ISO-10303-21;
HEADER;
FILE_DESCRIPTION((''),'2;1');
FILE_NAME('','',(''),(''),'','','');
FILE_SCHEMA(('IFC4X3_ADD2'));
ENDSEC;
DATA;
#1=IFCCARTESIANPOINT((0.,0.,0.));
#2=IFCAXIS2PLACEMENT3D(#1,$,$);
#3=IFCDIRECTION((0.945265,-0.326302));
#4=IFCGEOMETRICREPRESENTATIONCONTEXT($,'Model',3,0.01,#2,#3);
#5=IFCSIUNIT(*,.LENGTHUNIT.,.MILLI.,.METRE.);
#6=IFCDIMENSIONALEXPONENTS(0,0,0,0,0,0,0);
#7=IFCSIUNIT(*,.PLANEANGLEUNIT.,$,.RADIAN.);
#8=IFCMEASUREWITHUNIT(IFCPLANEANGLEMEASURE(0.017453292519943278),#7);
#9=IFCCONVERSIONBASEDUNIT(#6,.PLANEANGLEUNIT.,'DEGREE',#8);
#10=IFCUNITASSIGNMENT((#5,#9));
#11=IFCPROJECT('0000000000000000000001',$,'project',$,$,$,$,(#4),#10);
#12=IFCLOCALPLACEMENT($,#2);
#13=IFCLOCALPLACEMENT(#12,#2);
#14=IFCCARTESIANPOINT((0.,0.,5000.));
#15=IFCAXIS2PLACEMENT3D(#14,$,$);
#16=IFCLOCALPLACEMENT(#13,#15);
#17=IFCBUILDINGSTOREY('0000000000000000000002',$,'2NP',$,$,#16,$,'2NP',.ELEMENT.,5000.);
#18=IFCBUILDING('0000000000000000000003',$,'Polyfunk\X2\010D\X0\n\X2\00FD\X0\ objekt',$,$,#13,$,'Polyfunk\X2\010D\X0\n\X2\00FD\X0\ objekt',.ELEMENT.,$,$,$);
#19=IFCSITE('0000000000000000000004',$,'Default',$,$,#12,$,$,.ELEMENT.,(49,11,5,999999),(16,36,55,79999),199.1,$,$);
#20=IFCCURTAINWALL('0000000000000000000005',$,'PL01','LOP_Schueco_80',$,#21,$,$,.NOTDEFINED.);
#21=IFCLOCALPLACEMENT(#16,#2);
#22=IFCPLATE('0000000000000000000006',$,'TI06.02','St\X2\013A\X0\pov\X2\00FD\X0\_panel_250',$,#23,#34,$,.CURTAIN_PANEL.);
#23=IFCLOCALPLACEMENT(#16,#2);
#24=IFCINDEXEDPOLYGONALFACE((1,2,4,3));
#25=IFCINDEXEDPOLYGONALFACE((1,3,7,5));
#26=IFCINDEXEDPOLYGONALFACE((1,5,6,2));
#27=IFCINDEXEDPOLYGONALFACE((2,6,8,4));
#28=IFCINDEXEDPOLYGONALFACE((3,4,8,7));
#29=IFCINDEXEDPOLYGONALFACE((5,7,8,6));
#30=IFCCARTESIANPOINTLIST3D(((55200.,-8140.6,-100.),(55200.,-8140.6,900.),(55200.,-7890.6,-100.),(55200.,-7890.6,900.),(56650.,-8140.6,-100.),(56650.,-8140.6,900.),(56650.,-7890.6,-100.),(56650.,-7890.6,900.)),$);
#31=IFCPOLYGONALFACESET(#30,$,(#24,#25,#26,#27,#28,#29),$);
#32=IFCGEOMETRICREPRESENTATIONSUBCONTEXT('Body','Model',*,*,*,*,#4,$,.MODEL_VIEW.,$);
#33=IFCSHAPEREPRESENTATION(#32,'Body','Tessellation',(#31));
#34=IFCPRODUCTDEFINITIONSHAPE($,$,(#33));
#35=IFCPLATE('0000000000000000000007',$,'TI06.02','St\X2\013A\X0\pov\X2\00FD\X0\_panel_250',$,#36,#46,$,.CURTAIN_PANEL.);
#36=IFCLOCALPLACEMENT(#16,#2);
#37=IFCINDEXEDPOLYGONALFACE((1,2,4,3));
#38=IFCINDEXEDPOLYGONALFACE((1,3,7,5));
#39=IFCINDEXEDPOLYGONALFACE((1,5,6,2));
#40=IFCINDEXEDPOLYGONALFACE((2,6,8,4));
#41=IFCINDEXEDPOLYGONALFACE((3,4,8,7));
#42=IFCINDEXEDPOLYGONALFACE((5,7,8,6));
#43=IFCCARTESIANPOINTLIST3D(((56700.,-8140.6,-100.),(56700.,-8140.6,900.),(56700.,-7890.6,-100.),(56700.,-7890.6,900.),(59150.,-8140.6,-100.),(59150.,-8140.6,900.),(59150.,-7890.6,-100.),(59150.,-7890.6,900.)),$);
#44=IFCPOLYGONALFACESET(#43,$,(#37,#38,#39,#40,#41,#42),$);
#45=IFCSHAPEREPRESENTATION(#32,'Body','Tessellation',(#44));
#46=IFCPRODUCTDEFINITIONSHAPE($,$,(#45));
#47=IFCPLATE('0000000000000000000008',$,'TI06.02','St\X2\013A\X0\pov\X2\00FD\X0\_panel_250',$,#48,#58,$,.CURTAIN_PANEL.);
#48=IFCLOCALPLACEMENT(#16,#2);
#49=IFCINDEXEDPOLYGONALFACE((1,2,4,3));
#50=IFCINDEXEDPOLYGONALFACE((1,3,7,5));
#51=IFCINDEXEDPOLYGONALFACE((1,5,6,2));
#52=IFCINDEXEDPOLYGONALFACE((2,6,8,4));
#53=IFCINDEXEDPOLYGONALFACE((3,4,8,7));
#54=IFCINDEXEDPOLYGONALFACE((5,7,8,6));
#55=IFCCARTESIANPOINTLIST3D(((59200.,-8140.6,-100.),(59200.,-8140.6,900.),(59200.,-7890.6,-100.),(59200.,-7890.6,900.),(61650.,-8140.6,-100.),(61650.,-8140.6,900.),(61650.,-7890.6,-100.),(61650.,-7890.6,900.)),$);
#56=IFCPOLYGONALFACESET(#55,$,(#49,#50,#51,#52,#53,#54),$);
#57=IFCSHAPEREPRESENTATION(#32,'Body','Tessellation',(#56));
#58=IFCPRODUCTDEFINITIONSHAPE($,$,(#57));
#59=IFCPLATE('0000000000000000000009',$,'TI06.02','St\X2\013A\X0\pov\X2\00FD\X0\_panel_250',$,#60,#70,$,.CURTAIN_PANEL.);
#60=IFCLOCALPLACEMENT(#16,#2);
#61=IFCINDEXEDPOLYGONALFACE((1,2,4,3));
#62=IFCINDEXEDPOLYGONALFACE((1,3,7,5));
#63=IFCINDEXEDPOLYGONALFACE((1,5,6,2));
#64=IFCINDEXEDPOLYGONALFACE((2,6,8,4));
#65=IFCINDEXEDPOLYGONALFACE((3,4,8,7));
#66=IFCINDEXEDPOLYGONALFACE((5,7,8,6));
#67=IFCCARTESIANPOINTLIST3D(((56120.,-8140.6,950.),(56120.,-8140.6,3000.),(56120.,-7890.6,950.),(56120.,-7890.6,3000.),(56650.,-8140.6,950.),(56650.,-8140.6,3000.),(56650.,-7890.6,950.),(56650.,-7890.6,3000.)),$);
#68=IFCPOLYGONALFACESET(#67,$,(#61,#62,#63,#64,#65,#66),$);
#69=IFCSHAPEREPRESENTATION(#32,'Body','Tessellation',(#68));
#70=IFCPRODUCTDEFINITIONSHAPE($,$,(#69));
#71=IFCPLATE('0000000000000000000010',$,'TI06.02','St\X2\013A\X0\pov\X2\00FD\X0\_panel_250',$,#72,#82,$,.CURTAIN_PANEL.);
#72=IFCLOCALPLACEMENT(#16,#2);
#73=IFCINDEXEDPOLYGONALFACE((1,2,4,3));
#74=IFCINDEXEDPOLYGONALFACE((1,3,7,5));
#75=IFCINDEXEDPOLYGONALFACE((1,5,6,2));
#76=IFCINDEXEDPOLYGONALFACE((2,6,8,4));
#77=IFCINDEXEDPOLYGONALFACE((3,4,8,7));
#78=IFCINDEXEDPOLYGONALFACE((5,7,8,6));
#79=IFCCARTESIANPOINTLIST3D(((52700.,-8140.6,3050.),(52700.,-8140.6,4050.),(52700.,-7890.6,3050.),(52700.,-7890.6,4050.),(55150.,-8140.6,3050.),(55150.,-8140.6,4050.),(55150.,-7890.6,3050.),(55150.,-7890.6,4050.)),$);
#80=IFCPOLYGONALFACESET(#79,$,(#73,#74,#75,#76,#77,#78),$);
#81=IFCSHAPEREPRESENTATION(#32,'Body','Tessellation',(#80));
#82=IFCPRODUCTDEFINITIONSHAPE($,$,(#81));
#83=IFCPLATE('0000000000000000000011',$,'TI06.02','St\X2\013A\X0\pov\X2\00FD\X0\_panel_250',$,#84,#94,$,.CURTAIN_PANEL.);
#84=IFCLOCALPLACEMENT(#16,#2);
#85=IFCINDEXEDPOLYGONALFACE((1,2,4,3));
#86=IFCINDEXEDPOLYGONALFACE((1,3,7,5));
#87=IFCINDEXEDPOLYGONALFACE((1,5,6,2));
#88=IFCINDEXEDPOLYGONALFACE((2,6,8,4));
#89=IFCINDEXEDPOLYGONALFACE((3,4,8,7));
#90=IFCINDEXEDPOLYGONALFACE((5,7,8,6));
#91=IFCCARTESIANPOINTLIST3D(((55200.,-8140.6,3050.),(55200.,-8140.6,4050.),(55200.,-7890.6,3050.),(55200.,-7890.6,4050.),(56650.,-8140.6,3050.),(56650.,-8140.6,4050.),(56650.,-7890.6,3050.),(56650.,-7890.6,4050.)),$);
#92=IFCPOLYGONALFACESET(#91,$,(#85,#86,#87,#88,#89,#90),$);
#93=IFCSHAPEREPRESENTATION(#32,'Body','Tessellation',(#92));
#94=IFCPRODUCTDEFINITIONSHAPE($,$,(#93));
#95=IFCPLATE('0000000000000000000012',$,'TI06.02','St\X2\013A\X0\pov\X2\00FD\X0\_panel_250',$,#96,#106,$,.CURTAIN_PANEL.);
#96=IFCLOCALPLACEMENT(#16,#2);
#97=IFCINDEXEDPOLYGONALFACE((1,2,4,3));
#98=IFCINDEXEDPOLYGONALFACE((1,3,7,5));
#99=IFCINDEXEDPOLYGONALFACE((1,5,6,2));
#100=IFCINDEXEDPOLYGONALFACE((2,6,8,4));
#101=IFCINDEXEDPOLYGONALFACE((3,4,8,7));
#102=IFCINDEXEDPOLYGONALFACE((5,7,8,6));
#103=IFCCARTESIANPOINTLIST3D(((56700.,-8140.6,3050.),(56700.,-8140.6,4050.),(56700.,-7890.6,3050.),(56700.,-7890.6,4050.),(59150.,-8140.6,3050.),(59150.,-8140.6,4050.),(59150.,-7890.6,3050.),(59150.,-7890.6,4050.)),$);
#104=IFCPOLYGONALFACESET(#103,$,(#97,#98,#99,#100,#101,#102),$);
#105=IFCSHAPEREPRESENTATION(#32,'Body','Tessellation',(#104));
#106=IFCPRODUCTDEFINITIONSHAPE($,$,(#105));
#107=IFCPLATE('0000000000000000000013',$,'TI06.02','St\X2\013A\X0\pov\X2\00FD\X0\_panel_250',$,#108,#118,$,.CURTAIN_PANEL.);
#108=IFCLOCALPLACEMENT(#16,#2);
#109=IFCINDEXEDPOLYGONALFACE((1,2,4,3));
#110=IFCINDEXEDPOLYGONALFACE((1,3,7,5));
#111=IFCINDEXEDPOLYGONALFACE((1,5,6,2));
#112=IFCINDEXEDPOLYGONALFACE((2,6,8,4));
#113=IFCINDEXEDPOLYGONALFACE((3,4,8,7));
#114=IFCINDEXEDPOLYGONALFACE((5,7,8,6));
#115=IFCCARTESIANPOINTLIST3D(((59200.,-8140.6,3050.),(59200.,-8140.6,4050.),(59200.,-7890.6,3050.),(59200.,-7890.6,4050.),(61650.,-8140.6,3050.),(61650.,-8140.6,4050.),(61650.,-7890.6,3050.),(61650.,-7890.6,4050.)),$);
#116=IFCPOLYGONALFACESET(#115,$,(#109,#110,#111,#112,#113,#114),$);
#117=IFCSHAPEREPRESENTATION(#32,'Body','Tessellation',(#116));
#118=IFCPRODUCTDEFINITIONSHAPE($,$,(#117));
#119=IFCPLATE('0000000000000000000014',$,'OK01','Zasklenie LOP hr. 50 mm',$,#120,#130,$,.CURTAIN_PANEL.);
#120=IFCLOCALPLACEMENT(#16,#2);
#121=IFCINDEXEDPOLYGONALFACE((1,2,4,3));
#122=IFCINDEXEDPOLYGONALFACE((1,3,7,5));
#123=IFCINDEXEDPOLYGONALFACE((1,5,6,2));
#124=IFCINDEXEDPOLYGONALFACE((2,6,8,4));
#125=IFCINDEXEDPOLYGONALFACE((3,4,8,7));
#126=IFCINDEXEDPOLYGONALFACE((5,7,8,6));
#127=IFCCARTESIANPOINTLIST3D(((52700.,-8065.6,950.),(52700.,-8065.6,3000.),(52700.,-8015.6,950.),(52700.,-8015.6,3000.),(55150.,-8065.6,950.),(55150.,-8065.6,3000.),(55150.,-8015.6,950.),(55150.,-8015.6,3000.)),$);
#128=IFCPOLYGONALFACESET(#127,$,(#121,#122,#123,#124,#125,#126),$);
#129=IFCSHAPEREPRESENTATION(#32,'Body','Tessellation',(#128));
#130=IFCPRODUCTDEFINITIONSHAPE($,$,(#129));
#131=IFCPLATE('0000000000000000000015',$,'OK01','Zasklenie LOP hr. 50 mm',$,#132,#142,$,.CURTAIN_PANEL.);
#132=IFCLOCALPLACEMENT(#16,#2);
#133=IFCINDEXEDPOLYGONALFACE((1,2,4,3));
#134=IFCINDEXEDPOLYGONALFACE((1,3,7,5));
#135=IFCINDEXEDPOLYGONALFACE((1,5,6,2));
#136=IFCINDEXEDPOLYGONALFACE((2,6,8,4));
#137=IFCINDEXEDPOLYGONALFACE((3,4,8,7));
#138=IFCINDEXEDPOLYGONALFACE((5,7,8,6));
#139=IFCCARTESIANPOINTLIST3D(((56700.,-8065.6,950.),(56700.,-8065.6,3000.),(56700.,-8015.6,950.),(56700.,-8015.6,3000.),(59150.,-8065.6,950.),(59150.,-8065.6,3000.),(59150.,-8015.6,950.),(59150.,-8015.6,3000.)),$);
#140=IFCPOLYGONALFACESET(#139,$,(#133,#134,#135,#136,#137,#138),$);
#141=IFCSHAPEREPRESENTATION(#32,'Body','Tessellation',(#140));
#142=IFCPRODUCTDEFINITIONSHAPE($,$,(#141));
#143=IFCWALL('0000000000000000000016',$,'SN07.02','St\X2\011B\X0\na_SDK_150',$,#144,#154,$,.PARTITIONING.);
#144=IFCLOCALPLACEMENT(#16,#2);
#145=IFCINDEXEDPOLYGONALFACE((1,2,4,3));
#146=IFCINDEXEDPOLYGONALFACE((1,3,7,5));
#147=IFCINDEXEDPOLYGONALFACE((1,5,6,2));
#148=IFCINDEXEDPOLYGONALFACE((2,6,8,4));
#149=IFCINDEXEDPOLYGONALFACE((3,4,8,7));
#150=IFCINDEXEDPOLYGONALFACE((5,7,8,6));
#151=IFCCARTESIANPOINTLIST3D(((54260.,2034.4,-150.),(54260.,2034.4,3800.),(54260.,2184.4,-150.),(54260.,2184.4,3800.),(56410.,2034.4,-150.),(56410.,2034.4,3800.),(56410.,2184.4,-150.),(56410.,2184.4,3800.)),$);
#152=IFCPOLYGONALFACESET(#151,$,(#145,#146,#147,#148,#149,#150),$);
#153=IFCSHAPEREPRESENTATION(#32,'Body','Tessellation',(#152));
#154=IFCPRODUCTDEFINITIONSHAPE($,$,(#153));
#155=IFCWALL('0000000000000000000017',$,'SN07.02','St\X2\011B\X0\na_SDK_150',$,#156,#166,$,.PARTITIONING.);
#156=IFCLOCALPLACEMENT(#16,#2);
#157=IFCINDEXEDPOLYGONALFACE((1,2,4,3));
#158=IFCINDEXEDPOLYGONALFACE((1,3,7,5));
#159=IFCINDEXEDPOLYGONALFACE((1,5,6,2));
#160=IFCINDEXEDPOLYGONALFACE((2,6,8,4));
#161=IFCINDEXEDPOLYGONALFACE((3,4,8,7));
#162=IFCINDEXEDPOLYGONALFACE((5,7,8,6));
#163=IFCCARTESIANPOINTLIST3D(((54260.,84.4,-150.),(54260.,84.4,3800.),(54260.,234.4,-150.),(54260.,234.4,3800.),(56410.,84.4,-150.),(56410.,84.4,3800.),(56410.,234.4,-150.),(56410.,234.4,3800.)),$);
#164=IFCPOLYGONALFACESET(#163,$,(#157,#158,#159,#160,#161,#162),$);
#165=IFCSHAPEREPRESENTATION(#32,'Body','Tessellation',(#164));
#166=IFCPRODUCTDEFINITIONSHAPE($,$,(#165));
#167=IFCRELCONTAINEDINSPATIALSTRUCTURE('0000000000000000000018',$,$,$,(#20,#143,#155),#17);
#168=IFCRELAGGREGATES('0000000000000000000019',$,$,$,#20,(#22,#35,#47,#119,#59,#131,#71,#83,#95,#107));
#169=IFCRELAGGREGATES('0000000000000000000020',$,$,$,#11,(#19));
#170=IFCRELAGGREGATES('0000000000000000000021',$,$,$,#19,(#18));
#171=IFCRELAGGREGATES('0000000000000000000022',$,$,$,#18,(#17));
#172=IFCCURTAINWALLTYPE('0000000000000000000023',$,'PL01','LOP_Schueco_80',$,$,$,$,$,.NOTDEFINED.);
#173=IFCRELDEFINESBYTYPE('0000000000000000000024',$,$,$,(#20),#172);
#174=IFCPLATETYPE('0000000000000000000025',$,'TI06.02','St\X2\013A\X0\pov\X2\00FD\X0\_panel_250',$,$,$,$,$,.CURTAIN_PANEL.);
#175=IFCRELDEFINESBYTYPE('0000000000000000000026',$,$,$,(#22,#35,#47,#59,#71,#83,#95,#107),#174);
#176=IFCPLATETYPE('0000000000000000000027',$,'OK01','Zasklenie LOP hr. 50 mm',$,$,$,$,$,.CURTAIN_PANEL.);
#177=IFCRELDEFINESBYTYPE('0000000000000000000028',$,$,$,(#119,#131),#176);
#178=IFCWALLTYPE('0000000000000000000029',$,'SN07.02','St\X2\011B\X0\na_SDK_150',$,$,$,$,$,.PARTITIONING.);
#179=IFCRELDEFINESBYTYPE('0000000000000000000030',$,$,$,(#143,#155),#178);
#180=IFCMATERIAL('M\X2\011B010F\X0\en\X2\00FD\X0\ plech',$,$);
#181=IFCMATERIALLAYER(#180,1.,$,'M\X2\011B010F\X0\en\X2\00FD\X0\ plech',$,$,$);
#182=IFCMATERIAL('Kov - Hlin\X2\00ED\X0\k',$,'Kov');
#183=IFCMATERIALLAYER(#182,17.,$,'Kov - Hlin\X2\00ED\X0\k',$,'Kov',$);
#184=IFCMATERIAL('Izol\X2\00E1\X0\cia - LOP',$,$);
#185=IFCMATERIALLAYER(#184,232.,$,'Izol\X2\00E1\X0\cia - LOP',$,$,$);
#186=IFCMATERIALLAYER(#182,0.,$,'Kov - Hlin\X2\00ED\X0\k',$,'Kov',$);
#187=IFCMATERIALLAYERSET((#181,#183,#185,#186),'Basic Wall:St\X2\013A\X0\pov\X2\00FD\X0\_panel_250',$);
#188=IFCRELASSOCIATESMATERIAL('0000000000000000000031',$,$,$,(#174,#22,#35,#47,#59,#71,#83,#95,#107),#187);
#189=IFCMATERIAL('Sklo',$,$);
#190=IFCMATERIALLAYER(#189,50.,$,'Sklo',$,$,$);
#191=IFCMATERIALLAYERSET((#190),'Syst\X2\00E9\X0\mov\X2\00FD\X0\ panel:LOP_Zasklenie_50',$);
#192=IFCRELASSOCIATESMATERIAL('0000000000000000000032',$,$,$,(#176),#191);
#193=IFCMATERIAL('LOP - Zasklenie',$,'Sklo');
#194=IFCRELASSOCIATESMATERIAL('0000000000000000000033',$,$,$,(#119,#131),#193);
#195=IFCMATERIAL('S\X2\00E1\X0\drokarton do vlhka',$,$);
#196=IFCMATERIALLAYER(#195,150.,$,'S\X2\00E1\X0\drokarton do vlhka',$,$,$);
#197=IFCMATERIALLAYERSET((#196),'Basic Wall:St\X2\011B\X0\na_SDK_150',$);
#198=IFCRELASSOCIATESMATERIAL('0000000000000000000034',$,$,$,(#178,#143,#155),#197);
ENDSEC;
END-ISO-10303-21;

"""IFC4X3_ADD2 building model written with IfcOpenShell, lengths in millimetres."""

from ifc_helpers import new_model, entity, si_unit, converted_unit, direction, frame, frame_2d, origin, origin_2d_with_axis, place, context, subcontext, project, spatial, polyline, rectangle, extrude, clip, bounded_halfspace, source, transform, mapped, material, layer, layer_set, layer_usage, type_object, type_shapes, element, aggregate, save


model = new_model("IFC4X3_ADD2")

# Units and contexts
model_context = context("Model", 3, precision=0.01, world=origin(), true_north=direction((0.945265, -0.326302)))
body_context = subcontext(model_context, "Body", "Model", "MODEL_VIEW")
ifc_project = project(units=[si_unit("LENGTHUNIT", "METRE", prefix="MILLI"), converted_unit("PLANEANGLEUNIT", "DEGREE", entity("IfcPlaneAngleMeasure", 0.017453292519943278), si_unit("PLANEANGLEUNIT", "RADIAN"), dimensions=[0, 0, 0, 0, 0, 0, 0])], contexts=[model_context])

# Site, building, storey
site_placement = place(None, origin())
site = spatial("IfcSite", under=ifc_project, at=site_placement, Name="Default", CompositionType="ELEMENT", RefLatitude=(49, 11, 5, 999999), RefLongitude=(16, 36, 55, 79999), RefElevation=199.1)
building_placement = place(site_placement, origin())
building = spatial("IfcBuilding", under=site, at=building_placement, Name="Polyfunkčný objekt", LongName="Polyfunkčný objekt", CompositionType="ELEMENT")
storey_placement = place(building_placement, frame((0.0, 0.0, 5000.0)))
storey = spatial("IfcBuildingStorey", under=building, at=storey_placement, Name="2NP", LongName="2NP", CompositionType="ELEMENT", Elevation=5000.0)

# Curtain wall, plates
curtain_wall_type = type_object("IfcCurtainWallType", Name="PL01", Description="LOP_Schueco_80", PredefinedType="NOTDEFINED")
curtain_wall_placement = place(storey_placement, frame((0.0, 0.0, -5000.0)))
curtain_wall = element("IfcCurtainWall", 1, at=curtain_wall_placement, inside=storey, type_object=curtain_wall_type, Name="PL01", Description="LOP_Schueco_80", PredefinedType="NOTDEFINED")
ifc_material_1 = material(Name="Měďený plech")
ifc_layer_1 = layer(ifc_material_1, 1.0, Name="Měďený plech")
ifc_material_2 = material(Name="Kov - Hliník", Category="Kov")
ifc_layer_2 = layer(ifc_material_2, 17.0, Name="Kov - Hliník", Category="Kov")
ifc_material_3 = material(Name="Izolácia - LOP")
ifc_layer_3 = layer(ifc_material_3, 232.0, Name="Izolácia - LOP")
ifc_layer_4 = layer(ifc_material_2, 0.0, Name="Kov - Hliník", Category="Kov")
ifc_layer_set_1 = layer_set([ifc_layer_1, ifc_layer_2, ifc_layer_3, ifc_layer_4], Name="Basic Wall:Stĺpový_panel_250")
ifc_layer_usage_1 = layer_usage(ifc_layer_set_1, "AXIS2", "POSITIVE", -125.0)
plate_type_1 = type_object("IfcPlateType", Name="TI06.02", Description="Stĺpový_panel_250", PredefinedType="CURTAIN_PANEL", material=ifc_layer_set_1)
plate_1_placement = place(storey_placement, frame((55200.0, -8015.6, -100.0)))
plate_1 = element("IfcPlate", 2, at=plate_1_placement, type_object=plate_type_1, material=ifc_layer_usage_1, Name="TI06.02", Description="Stĺpový_panel_250", PredefinedType="CURTAIN_PANEL", context=body_context, shape_type="SweptSolid", body=[
    extrude(rectangle(XDim=250.0, YDim=1450.0, at=frame_2d((0.0, 0.0), x_axis=(1.0, 0.0))), frame((725.0, 0.0, 0.0), z_axis=(0.0, 0.0, 1.0), x_axis=(0.0, 1.0, 0.0)), (0.0, 0.0, 1.0), 1000.0),
])
ifc_layer_usage_2 = layer_usage(ifc_layer_set_1, "AXIS2", "POSITIVE", -125.0)
plate_2_placement = place(storey_placement, frame((56700.0, -8015.6, -100.0)))
plate_2 = element("IfcPlate", 3, at=plate_2_placement, type_object=plate_type_1, material=ifc_layer_usage_2, Name="TI06.02", Description="Stĺpový_panel_250", PredefinedType="CURTAIN_PANEL", context=body_context, shape_type="SweptSolid", body=[
    extrude(rectangle(XDim=250.0, YDim=2450.0, at=frame_2d((0.0, 0.0), x_axis=(1.0, 0.0))), frame((1225.0, 0.0, 0.0), z_axis=(0.0, 0.0, 1.0), x_axis=(0.0, 1.0, 0.0)), (0.0, 0.0, 1.0), 1000.0),
])
ifc_layer_usage_3 = layer_usage(ifc_layer_set_1, "AXIS2", "POSITIVE", -125.0)
plate_3_placement = place(storey_placement, frame((59200.0, -8015.6, -100.0)))
plate_3 = element("IfcPlate", 4, at=plate_3_placement, type_object=plate_type_1, material=ifc_layer_usage_3, Name="TI06.02", Description="Stĺpový_panel_250", PredefinedType="CURTAIN_PANEL", context=body_context, shape_type="SweptSolid", body=[
    extrude(rectangle(XDim=250.0, YDim=2450.0, at=frame_2d((0.0, 0.0), x_axis=(1.0, 0.0))), frame((1225.0, 0.0, 0.0), z_axis=(0.0, 0.0, 1.0), x_axis=(0.0, 1.0, 0.0)), (0.0, 0.0, 1.0), 1000.0),
])
ifc_layer_usage_4 = layer_usage(ifc_layer_set_1, "AXIS2", "POSITIVE", -125.0)
plate_4_placement = place(storey_placement, frame((56120.0, -8015.6, 950.0)))
plate_4 = element("IfcPlate", 5, at=plate_4_placement, type_object=plate_type_1, material=ifc_layer_usage_4, Name="TI06.02", Description="Stĺpový_panel_250", PredefinedType="CURTAIN_PANEL", context=body_context, shape_type="SweptSolid", body=[
    extrude(rectangle(XDim=250.0, YDim=530.0, at=origin_2d_with_axis()), frame((265.0, 0.0, 0.0), z_axis=(0.0, 0.0, 1.0), x_axis=(0.0, 1.0, 0.0)), (0.0, 0.0, 1.0), 2050.0),
])
ifc_layer_usage_5 = layer_usage(ifc_layer_set_1, "AXIS2", "POSITIVE", -125.0)
plate_5_placement = place(storey_placement, frame((52700.0, -8015.6, 3050.0)))
plate_5 = element("IfcPlate", 6, at=plate_5_placement, type_object=plate_type_1, material=ifc_layer_usage_5, Name="TI06.02", Description="Stĺpový_panel_250", PredefinedType="CURTAIN_PANEL", context=body_context, shape_type="SweptSolid", body=[
    extrude(rectangle(XDim=250.0, YDim=2450.0, at=frame_2d((0.0, 0.0), x_axis=(1.0, 0.0))), frame((1225.0, 0.0, 0.0), z_axis=(0.0, 0.0, 1.0), x_axis=(0.0, 1.0, 0.0)), (0.0, 0.0, 1.0), 1000.0),
])
ifc_layer_usage_6 = layer_usage(ifc_layer_set_1, "AXIS2", "POSITIVE", -125.0)
plate_6_placement = place(storey_placement, frame((55200.0, -8015.6, 3050.0)))
plate_6 = element("IfcPlate", 7, at=plate_6_placement, type_object=plate_type_1, material=ifc_layer_usage_6, Name="TI06.02", Description="Stĺpový_panel_250", PredefinedType="CURTAIN_PANEL", context=body_context, shape_type="SweptSolid", body=[
    extrude(rectangle(XDim=250.0, YDim=1450.0, at=frame_2d((0.0, 0.0), x_axis=(1.0, 0.0))), frame((725.0, 0.0, 0.0), z_axis=(0.0, 0.0, 1.0), x_axis=(0.0, 1.0, 0.0)), (0.0, 0.0, 1.0), 1000.0),
])
ifc_layer_usage_7 = layer_usage(ifc_layer_set_1, "AXIS2", "POSITIVE", -125.0)
plate_7_placement = place(storey_placement, frame((56700.0, -8015.6, 3050.0)))
plate_7 = element("IfcPlate", 8, at=plate_7_placement, type_object=plate_type_1, material=ifc_layer_usage_7, Name="TI06.02", Description="Stĺpový_panel_250", PredefinedType="CURTAIN_PANEL", context=body_context, shape_type="SweptSolid", body=[
    extrude(rectangle(XDim=250.0, YDim=2450.0, at=frame_2d((0.0, 0.0), x_axis=(1.0, 0.0))), frame((1225.0, 0.0, 0.0), z_axis=(0.0, 0.0, 1.0), x_axis=(0.0, 1.0, 0.0)), (0.0, 0.0, 1.0), 1000.0),
])
ifc_layer_usage_8 = layer_usage(ifc_layer_set_1, "AXIS2", "POSITIVE", -125.0)
plate_8_placement = place(storey_placement, frame((59200.0, -8015.6, 3050.0)))
plate_8 = element("IfcPlate", 9, at=plate_8_placement, type_object=plate_type_1, material=ifc_layer_usage_8, Name="TI06.02", Description="Stĺpový_panel_250", PredefinedType="CURTAIN_PANEL", context=body_context, shape_type="SweptSolid", body=[
    extrude(rectangle(XDim=250.0, YDim=2450.0, at=frame_2d((0.0, 0.0), x_axis=(1.0, 0.0))), frame((1225.0, 0.0, 0.0), z_axis=(0.0, 0.0, 1.0), x_axis=(0.0, 1.0, 0.0)), (0.0, 0.0, 1.0), 1000.0),
])
ifc_material_4 = material(Name="LOP - Zasklenie", Category="Sklo")
ifc_material_5 = material(Name="Sklo")
ifc_layer_5 = layer(ifc_material_5, 50.0, Name="Sklo")
ifc_layer_set_2 = layer_set([ifc_layer_5], Name="Systémový panel:LOP_Zasklenie_50")
plate_type_2 = type_object("IfcPlateType", Name="OK01", Description="Zasklenie LOP hr. 50 mm", PredefinedType="CURTAIN_PANEL", material=ifc_layer_set_2)
shared_shape_1 = source(origin(), body_context, "Body", "SweptSolid", [
    extrude(rectangle(XDim=50.0, YDim=2450.0, at=origin_2d_with_axis()), frame((0.0, -25.0, 0.0), z_axis=(0.0, 0.0, 1.0), x_axis=(0.0, 1.0, 0.0)), (0.0, 0.0, 1.0), 2050.0),
])
type_shapes(plate_type_2, [shared_shape_1])
plate_9_placement = place(curtain_wall_placement, frame((53925.0, -8015.6, 5950.0)))
plate_9 = element("IfcPlate", 10, at=plate_9_placement, type_object=plate_type_2, material=ifc_material_4, Name="OK01", Description="Zasklenie LOP hr. 50 mm", PredefinedType="CURTAIN_PANEL", context=body_context, shape_type="MappedRepresentation", body=[
    mapped(shared_shape_1, transform((0.0, 0.0, 0.0), scale=1.0)),
])
plate_10_placement = place(curtain_wall_placement, frame((57925.0, -8015.6, 5950.0)))
plate_10 = element("IfcPlate", 11, at=plate_10_placement, type_object=plate_type_2, material=ifc_material_4, Name="OK01", Description="Zasklenie LOP hr. 50 mm", PredefinedType="CURTAIN_PANEL", context=body_context, shape_type="MappedRepresentation", body=[
    mapped(shared_shape_1, transform((0.0, 0.0, 0.0), scale=1.0)),
])

# Walls
ifc_material_6 = material(Name="Sádrokarton do vlhka")
ifc_layer_6 = layer(ifc_material_6, 150.0, Name="Sádrokarton do vlhka")
ifc_layer_set_3 = layer_set([ifc_layer_6], Name="Basic Wall:Stěna_SDK_150")
wall_type_1 = type_object("IfcWallType", Name="SN07.02", Description="Stěna_SDK_150", PredefinedType="PARTITIONING", material=ifc_layer_set_3)
wall_1_placement = place(storey_placement, frame((56410.0, 2109.4, -150.0), z_axis=(0.0, 0.0, 1.0), x_axis=(-1.0, 0.0, 0.0)))
element("IfcWall", 12, at=wall_1_placement, inside=storey, type_object=wall_type_1, material=ifc_layer_set_3, Name="SN07.02", Description="Stěna_SDK_150", PredefinedType="PARTITIONING", context=body_context, shape_type="Clipping", body=[
    clip(clip(extrude(rectangle(XDim=2150.0, YDim=150.0, at=frame_2d((1075.0, 0.0), x_axis=(-1.0, 0.0))), origin(), (0.0, 0.0, 1.0), 3950.0), bounded_halfspace(frame((2150.0, -75.0, 0.0)), True, frame((2150.0, -75.0, 0.0)), polyline([(0.0, 0.0), (0.0, 150.0), (-2150.0, 150.0), (-2150.0, 0.0), (0.0, 0.0)]))), bounded_halfspace(frame((0.0, -75.0, 3950.0), z_axis=(0.0, 0.0, -1.0), x_axis=(-1.0, 0.0, 0.0)), True, frame((0.0, -75.0, 3950.0)), polyline([(0.0, 0.0), (2150.0, 0.0), (2150.0, 150.0), (0.0, 150.0), (0.0, 0.0)]))),
])
wall_2_placement = place(storey_placement, frame((56410.0, 159.4, -150.0), z_axis=(0.0, 0.0, 1.0), x_axis=(-1.0, 0.0, 0.0)))
element("IfcWall", 13, at=wall_2_placement, inside=storey, type_object=wall_type_1, material=ifc_layer_set_3, Name="SN07.02", Description="Stěna_SDK_150", PredefinedType="PARTITIONING", context=body_context, shape_type="Clipping", body=[
    clip(clip(extrude(rectangle(XDim=2150.0, YDim=150.0, at=frame_2d((1075.0, 0.0), x_axis=(-1.0, 0.0))), origin(), (0.0, 0.0, 1.0), 3950.0), bounded_halfspace(frame((2150.0, -75.0, 0.0)), True, frame((2150.0, -75.0, 0.0)), polyline([(0.0, 0.0), (0.0, 150.0), (-2150.0, 150.0), (-2150.0, 0.0), (0.0, 0.0)]))), bounded_halfspace(frame((0.0, -75.0, 3950.0), z_axis=(0.0, 0.0, -1.0), x_axis=(-1.0, 0.0, 0.0)), True, frame((0.0, -75.0, 3950.0)), polyline([(0.0, 0.0), (2150.0, 0.0), (2150.0, 150.0), (0.0, 150.0), (0.0, 0.0)]))),
])

aggregate(curtain_wall, [plate_1, plate_2, plate_3, plate_9, plate_4, plate_10, plate_5, plate_6, plate_7, plate_8])

save(model, "model.ifc")
